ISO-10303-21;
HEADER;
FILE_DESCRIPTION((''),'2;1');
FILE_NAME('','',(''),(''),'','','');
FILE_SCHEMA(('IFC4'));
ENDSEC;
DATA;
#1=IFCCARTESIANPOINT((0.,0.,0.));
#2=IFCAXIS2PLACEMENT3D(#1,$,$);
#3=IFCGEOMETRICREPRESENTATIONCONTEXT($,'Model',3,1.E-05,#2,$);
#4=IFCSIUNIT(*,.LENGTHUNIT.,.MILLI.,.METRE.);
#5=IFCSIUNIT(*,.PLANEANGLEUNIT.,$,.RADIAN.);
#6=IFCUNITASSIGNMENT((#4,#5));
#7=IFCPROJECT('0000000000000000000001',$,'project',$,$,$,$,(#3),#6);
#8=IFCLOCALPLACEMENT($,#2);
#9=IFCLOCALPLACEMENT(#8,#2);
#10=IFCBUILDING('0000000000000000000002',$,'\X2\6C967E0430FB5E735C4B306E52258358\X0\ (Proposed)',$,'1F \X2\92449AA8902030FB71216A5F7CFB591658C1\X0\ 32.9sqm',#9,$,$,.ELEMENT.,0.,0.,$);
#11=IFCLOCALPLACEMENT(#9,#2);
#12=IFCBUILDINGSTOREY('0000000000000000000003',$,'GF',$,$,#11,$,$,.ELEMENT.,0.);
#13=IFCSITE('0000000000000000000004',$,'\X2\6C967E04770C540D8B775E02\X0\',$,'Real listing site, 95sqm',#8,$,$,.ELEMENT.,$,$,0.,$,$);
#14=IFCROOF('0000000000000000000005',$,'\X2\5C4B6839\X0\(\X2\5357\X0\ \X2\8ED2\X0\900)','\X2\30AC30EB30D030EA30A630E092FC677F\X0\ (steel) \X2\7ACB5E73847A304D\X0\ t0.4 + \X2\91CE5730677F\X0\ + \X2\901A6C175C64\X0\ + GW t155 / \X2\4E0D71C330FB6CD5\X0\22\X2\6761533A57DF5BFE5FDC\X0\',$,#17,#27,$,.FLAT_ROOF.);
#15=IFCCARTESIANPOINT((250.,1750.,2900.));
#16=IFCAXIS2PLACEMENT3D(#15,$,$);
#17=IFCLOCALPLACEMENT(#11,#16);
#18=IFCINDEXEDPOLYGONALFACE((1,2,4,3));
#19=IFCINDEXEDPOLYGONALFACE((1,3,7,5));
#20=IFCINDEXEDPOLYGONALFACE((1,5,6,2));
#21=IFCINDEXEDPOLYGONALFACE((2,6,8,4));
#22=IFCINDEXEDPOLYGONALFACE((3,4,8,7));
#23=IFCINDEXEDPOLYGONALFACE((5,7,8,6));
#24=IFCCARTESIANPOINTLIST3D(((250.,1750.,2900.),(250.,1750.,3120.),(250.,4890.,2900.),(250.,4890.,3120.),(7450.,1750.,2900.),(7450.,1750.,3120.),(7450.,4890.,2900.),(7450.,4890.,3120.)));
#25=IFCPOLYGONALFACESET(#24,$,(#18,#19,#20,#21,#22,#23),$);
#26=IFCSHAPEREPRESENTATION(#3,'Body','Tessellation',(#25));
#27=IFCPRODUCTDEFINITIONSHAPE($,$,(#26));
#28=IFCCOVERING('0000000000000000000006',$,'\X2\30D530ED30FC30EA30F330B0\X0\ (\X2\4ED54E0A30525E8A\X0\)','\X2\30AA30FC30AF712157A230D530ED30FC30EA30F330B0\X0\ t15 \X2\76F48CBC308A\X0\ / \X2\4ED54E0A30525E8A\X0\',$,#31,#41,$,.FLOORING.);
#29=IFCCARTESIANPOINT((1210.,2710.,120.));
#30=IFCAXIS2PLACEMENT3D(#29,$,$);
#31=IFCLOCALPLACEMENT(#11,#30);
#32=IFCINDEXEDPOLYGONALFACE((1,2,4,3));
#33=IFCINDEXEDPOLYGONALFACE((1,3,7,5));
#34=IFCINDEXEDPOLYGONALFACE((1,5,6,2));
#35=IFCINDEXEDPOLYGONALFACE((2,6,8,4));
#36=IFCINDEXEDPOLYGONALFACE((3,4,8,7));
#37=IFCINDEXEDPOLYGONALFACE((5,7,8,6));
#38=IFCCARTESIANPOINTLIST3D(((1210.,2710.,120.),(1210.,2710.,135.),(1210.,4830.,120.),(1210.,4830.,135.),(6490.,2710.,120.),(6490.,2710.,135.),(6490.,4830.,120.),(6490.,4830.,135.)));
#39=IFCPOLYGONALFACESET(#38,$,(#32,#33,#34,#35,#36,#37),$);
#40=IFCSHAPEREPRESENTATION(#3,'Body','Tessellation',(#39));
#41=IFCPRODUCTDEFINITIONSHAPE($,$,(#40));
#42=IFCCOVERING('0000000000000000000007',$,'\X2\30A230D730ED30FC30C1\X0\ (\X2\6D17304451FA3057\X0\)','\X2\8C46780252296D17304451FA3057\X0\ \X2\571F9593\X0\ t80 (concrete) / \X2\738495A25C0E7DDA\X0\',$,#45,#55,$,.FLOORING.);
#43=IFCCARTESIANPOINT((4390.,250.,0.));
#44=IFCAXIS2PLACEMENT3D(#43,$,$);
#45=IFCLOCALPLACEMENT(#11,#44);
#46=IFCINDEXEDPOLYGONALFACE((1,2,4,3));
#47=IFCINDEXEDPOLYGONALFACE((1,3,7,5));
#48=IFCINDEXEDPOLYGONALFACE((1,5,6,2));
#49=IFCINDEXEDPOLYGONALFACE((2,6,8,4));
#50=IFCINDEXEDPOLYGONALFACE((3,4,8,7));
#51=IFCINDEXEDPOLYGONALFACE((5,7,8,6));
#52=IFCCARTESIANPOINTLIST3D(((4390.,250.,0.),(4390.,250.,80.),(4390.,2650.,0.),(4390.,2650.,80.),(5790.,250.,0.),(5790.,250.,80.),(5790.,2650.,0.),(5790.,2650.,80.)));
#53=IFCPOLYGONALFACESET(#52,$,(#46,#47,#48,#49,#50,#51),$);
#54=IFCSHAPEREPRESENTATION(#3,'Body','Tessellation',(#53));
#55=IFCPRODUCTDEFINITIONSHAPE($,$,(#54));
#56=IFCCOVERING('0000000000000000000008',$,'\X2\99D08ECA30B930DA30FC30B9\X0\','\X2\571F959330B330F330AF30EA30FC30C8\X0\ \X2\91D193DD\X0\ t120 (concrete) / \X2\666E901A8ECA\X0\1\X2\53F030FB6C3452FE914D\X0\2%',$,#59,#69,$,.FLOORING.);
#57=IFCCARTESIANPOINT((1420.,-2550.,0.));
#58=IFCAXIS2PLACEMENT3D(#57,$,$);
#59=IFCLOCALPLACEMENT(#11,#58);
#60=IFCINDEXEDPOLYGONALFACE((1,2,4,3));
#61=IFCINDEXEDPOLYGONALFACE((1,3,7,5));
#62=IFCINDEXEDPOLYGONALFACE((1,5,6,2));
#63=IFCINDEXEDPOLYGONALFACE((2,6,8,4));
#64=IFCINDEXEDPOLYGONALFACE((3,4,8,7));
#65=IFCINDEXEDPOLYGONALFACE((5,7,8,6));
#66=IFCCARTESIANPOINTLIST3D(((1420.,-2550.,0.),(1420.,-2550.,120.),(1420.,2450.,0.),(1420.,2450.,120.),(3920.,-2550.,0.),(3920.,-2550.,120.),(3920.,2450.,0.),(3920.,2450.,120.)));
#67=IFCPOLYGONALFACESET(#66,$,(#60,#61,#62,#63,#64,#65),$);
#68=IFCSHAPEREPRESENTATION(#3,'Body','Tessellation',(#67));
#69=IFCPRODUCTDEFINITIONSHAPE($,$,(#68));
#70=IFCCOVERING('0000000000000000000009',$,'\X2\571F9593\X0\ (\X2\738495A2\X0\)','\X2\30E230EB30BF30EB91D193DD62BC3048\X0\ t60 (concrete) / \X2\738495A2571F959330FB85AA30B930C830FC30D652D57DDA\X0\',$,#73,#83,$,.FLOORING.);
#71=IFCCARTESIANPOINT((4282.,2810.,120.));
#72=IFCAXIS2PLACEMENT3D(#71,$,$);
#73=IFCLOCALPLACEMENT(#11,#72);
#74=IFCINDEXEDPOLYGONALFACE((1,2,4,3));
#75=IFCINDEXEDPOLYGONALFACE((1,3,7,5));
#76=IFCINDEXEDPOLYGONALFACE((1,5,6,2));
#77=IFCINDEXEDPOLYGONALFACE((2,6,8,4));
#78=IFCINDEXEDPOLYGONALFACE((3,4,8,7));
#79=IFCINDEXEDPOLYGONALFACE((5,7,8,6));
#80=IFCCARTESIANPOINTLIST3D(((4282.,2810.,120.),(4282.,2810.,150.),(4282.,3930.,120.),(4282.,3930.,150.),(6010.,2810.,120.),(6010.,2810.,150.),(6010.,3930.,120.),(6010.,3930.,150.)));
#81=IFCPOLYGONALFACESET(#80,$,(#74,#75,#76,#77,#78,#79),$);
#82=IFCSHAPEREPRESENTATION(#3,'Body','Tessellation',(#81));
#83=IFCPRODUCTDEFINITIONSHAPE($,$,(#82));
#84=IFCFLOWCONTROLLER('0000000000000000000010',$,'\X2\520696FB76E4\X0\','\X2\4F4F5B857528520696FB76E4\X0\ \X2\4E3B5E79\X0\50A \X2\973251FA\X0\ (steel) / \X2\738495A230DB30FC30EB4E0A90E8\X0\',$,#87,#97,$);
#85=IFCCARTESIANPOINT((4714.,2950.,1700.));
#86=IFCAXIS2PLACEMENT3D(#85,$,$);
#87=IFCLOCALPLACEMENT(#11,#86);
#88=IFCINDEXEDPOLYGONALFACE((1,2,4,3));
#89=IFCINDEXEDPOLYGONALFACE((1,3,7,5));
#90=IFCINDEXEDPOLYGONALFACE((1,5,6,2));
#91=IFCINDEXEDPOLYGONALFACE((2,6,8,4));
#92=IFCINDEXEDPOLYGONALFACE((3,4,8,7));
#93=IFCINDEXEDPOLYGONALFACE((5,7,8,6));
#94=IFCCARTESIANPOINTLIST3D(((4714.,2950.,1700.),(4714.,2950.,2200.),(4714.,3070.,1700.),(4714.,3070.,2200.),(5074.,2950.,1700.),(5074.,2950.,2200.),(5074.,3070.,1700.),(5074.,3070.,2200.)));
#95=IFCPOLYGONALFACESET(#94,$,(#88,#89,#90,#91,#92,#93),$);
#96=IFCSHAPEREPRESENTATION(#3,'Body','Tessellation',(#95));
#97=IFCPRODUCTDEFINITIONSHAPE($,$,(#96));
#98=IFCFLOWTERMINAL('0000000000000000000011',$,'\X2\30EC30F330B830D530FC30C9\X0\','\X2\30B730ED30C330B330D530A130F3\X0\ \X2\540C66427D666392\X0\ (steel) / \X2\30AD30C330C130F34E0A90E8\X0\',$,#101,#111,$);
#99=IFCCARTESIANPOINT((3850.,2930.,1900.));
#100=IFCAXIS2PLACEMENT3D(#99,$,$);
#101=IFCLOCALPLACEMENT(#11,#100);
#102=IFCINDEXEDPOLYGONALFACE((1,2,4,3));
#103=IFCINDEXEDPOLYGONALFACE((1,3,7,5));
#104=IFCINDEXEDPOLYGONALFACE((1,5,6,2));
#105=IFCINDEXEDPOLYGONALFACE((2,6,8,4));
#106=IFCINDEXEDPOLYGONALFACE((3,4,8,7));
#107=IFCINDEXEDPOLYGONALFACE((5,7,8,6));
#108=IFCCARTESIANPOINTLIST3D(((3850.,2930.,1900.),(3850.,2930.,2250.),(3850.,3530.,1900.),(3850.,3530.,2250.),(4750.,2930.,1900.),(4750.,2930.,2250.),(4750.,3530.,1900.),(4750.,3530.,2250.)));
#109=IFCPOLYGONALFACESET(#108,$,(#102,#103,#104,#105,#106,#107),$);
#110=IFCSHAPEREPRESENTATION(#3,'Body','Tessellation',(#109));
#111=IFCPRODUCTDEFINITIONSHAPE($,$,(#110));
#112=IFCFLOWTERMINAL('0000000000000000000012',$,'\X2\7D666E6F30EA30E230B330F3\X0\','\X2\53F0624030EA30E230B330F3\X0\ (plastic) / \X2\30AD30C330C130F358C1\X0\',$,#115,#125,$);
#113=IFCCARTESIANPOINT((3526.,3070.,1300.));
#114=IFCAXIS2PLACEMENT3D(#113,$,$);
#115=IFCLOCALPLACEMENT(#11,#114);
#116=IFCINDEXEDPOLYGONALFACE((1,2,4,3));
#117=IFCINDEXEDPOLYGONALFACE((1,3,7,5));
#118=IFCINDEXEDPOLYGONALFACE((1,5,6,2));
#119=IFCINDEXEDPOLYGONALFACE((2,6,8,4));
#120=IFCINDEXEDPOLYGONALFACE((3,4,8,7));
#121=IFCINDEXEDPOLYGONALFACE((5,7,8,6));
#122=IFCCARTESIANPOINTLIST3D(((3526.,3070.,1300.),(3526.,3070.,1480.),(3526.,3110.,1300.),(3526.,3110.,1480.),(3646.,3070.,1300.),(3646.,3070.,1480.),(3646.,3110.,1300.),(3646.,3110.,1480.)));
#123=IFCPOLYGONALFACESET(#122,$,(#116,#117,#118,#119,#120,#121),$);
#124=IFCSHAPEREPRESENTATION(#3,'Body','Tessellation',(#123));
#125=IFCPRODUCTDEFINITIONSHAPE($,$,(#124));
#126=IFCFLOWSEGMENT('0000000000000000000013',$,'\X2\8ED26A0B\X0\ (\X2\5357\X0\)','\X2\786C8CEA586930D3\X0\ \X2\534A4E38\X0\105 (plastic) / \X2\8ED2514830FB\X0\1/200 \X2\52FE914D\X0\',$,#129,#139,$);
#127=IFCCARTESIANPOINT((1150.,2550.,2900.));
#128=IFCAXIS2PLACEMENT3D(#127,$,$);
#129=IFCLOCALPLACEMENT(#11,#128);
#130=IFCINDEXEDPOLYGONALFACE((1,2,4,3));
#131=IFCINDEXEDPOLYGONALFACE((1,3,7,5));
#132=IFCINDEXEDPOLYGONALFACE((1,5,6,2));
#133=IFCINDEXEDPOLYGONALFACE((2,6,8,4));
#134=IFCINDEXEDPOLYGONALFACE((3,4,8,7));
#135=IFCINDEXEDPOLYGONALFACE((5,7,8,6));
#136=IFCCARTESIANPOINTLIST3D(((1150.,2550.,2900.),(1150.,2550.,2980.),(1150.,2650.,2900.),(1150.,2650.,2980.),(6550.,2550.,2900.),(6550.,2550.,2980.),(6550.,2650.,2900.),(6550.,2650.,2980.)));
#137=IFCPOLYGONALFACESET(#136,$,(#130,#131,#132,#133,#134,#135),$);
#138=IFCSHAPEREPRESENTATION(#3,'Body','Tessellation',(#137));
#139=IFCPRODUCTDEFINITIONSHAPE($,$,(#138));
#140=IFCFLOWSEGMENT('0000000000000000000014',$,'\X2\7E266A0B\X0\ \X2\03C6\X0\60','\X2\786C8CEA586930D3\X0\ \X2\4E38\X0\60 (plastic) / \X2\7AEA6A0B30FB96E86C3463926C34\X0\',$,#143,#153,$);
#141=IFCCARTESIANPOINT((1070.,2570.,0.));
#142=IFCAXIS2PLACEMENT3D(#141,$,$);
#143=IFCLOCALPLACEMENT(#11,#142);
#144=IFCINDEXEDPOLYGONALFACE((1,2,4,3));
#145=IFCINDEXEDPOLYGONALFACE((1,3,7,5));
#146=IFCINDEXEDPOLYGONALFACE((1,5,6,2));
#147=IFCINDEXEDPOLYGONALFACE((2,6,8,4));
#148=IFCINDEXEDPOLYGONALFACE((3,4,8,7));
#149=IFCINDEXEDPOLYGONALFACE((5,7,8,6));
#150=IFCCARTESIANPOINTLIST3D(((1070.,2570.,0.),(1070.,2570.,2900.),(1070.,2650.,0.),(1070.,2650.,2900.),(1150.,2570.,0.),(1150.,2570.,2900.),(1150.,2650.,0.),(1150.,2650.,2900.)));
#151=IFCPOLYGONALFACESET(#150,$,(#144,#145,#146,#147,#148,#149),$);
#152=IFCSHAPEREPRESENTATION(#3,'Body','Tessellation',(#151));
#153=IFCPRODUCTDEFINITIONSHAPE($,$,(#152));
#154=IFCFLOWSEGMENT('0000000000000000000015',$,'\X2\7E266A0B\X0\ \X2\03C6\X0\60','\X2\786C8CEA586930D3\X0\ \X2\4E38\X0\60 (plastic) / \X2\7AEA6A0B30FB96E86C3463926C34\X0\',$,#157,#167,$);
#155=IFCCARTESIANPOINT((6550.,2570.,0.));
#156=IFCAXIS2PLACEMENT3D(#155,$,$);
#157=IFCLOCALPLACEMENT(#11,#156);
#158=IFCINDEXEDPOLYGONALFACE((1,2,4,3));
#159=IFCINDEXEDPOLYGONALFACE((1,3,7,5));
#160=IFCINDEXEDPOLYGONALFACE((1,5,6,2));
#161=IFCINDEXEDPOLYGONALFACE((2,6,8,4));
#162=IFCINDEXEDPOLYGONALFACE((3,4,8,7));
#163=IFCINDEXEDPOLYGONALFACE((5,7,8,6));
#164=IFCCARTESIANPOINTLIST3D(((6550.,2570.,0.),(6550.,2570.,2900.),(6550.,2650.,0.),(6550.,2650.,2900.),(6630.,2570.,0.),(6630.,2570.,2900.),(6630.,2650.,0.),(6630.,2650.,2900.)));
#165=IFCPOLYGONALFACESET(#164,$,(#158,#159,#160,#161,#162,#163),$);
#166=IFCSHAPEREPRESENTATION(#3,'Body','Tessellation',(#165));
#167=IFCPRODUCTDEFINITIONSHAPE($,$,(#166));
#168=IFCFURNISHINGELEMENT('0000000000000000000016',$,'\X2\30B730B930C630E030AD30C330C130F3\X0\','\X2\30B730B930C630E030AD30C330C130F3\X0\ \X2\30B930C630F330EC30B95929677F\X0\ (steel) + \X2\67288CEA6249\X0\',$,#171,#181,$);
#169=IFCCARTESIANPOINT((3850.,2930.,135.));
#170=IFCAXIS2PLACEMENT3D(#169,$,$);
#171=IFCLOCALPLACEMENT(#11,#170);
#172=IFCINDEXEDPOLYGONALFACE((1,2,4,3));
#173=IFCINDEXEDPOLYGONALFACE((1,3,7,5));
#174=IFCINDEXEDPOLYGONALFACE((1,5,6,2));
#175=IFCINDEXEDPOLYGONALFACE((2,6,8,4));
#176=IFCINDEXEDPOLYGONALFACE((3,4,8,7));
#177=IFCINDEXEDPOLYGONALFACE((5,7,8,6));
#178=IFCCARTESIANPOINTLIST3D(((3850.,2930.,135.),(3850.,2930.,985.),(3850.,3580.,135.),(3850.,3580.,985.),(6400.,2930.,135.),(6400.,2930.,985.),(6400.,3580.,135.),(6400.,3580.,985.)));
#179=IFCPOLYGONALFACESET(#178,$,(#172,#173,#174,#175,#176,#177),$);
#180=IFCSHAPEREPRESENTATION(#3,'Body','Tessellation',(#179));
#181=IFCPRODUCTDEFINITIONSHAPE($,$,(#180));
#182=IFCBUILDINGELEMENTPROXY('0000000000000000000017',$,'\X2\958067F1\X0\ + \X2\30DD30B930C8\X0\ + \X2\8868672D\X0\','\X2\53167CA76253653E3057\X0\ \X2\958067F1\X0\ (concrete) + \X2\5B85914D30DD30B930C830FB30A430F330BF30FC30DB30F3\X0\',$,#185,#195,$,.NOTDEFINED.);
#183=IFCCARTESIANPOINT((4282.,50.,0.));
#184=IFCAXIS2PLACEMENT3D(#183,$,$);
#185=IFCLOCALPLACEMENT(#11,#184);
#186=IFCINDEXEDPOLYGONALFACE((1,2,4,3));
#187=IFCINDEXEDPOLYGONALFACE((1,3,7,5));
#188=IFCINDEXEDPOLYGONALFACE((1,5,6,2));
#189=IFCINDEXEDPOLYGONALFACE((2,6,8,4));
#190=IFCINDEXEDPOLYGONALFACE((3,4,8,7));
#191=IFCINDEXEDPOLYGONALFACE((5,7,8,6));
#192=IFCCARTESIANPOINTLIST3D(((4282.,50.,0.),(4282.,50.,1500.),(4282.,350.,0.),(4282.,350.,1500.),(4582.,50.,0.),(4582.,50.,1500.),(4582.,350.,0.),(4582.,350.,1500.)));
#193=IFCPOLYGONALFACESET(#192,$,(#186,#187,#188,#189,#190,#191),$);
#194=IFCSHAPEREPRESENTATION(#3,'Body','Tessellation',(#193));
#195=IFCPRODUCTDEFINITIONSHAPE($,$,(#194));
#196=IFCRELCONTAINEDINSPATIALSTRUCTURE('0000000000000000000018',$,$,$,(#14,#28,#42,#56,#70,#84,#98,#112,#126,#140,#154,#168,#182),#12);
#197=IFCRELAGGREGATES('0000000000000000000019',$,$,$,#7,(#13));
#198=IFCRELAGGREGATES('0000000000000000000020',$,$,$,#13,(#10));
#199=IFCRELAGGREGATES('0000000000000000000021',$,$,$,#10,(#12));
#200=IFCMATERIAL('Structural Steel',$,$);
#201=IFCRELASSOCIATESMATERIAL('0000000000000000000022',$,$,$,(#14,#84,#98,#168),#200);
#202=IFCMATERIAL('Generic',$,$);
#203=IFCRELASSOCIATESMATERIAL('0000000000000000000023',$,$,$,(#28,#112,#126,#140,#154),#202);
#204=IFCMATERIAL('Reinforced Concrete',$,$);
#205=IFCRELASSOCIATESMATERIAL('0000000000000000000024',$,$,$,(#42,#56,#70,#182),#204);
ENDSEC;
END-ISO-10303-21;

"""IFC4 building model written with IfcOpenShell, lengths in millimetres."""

from ifc_helpers import new_model, si_unit, frame, frame_2d, origin, place, context, project, spatial, rectangle, extrude, material, element, save


model = new_model("IFC4")

# Units and contexts
model_context = context("Model", 3, precision=1e-05, world=origin())
ifc_project = project(units=[si_unit("LENGTHUNIT", "METRE", prefix="MILLI"), si_unit("PLANEANGLEUNIT", "RADIAN")], contexts=[model_context])

# Site, building, storey
site_placement = place(None, origin())
site = spatial("IfcSite", under=ifc_project, at=site_placement, Name="沖縄県名護市", ObjectType="Real listing site, 95sqm", CompositionType="ELEMENT", RefElevation=0.0)
building_placement = place(site_placement, origin())
building = spatial("IfcBuilding", under=site, at=building_placement, Name="沖縄・平屋の別荘 (Proposed)", ObjectType="1F 鉄骨造・無機系外壁 32.9sqm", CompositionType="ELEMENT", ElevationOfRefHeight=0.0, ElevationOfTerrain=0.0)
storey_placement = place(building_placement, origin())
storey = spatial("IfcBuildingStorey", under=building, at=storey_placement, Name="GF", CompositionType="ELEMENT", Elevation=0.0)

# Shared definitions
ifc_material_1 = material(Name="Reinforced Concrete")

# Roof
ifc_material_2 = material(Name="Structural Steel")
roof_placement = place(storey_placement, frame((250.0, 1750.0, 2900.0)))
element("IfcRoof", 1, at=roof_placement, inside=storey, material=ifc_material_2, Name="屋根(南 軒900)", Description="ガルバリウム鋼板 (steel) 立平葺き t0.4 + 野地板 + 通気層 + GW t155 / 不燃・法22条区域対応", PredefinedType="FLAT_ROOF", context=model_context, shape_type="SweptSolid", body=[
    extrude(rectangle(XDim=7200.0, YDim=3140.0, at=frame_2d((3600.0, 1570.0))), frame((250.0, 1750.0, 2900.0)), (0.0, 0.0, 1.0), 220.0),
])

# Coverings
ifc_material_3 = material(Name="Generic")
covering_1_placement = place(storey_placement, frame((1210.0, 2710.0, 120.0)))
element("IfcCovering", 2, at=covering_1_placement, inside=storey, material=ifc_material_3, Name="フローリング (仕上げ床)", Description="オーク無垢フローリング t15 直貼り / 仕上げ床", PredefinedType="FLOORING", context=model_context, shape_type="SweptSolid", body=[
    extrude(rectangle(XDim=5280.0, YDim=2120.0, at=frame_2d((2640.0, 1060.0))), frame((1210.0, 2710.0, 120.0)), (0.0, 0.0, 1.0), 15.0),
])
covering_2_placement = place(storey_placement, frame((4390.0, 250.0, 0.0)))
element("IfcCovering", 3, at=covering_2_placement, inside=storey, material=ifc_material_1, Name="アプローチ (洗い出し)", Description="豆砂利洗い出し 土間 t80 (concrete) / 玄関導線", PredefinedType="FLOORING", context=model_context, shape_type="SweptSolid", body=[
    extrude(rectangle(XDim=1400.0, YDim=2400.0, at=frame_2d((700.0, 1200.0))), frame((4390.0, 250.0, 0.0)), (0.0, 0.0, 1.0), 80.0),
])
covering_3_placement = place(storey_placement, frame((1420.0, -2550.0, 0.0)))
element("IfcCovering", 4, at=covering_3_placement, inside=storey, material=ifc_material_1, Name="駐車スペース", Description="土間コンクリート 金鏝 t120 (concrete) / 普通車1台・水勾配2%", PredefinedType="FLOORING", context=model_context, shape_type="SweptSolid", body=[
    extrude(rectangle(XDim=2500.0, YDim=5000.0, at=frame_2d((1250.0, 2500.0))), frame((1420.0, -2550.0, 0.0)), (0.0, 0.0, 1.0), 120.0),
])
covering_4_placement = place(storey_placement, frame((4282.0, 2810.0, 120.0)))
element("IfcCovering", 5, at=covering_4_placement, inside=storey, material=ifc_material_1, Name="土間 (玄関)", Description="モルタル金鏝押え t60 (concrete) / 玄関土間・薪ストーブ動線", PredefinedType="FLOORING", context=model_context, shape_type="SweptSolid", body=[
    extrude(rectangle(XDim=1728.0, YDim=1120.0, at=frame_2d((864.0, 560.0))), frame((4282.0, 2810.0, 120.0)), (0.0, 0.0, 1.0), 30.0),
])

# Flow controller
flow_controller_placement = place(storey_placement, frame((4714.0, 2950.0, 1700.0)))
element("IfcFlowController", 6, at=flow_controller_placement, inside=storey, material=ifc_material_2, Name="分電盤", Description="住宅用分電盤 主幹50A 露出 (steel) / 玄関ホール上部", context=model_context, shape_type="SweptSolid", body=[
    extrude(rectangle(XDim=360.0, YDim=120.0, at=frame_2d((180.0, 60.0))), frame((4714.0, 2950.0, 1700.0)), (0.0, 0.0, 1.0), 500.0),
])

# Flow terminals
flow_terminal_1_placement = place(storey_placement, frame((3850.0, 2930.0, 1900.0)))
element("IfcFlowTerminal", 7, at=flow_terminal_1_placement, inside=storey, material=ifc_material_2, Name="レンジフード", Description="シロッコファン 同時給排 (steel) / キッチン上部", context=model_context, shape_type="SweptSolid", body=[
    extrude(rectangle(XDim=900.0, YDim=600.0, at=frame_2d((450.0, 300.0))), frame((3850.0, 2930.0, 1900.0)), (0.0, 0.0, 1.0), 350.0),
])
flow_terminal_2_placement = place(storey_placement, frame((3526.0, 3070.0, 1300.0)))
element("IfcFlowTerminal", 8, at=flow_terminal_2_placement, inside=storey, material=ifc_material_3, Name="給湯リモコン", Description="台所リモコン (plastic) / キッチン壁", context=model_context, shape_type="SweptSolid", body=[
    extrude(rectangle(XDim=120.0, YDim=40.0, at=frame_2d((60.0, 20.0))), frame((3526.0, 3070.0, 1300.0)), (0.0, 0.0, 1.0), 180.0),
])

# Flow segments
flow_segment_1_placement = place(storey_placement, frame((1150.0, 2550.0, 2900.0)))
element("IfcFlowSegment", 9, at=flow_segment_1_placement, inside=storey, material=ifc_material_3, Name="軒樋 (南)", Description="硬質塩ビ 半丸105 (plastic) / 軒先・1/200 勾配", context=model_context, shape_type="SweptSolid", body=[
    extrude(rectangle(XDim=5400.0, YDim=100.0, at=frame_2d((2700.0, 50.0))), frame((1150.0, 2550.0, 2900.0)), (0.0, 0.0, 1.0), 80.0),
])
flow_segment_2_placement = place(storey_placement, frame((1070.0, 2570.0, 0.0)))
element("IfcFlowSegment", 10, at=flow_segment_2_placement, inside=storey, material=ifc_material_3, Name="縦樋 φ60", Description="硬質塩ビ 丸60 (plastic) / 竪樋・雨水排水", context=model_context, shape_type="SweptSolid", body=[
    extrude(rectangle(XDim=80.0, YDim=80.0, at=frame_2d((40.0, 40.0))), frame((1070.0, 2570.0, 0.0)), (0.0, 0.0, 1.0), 2900.0),
])
flow_segment_3_placement = place(storey_placement, frame((6550.0, 2570.0, 0.0)))
element("IfcFlowSegment", 11, at=flow_segment_3_placement, inside=storey, material=ifc_material_3, Name="縦樋 φ60", Description="硬質塩ビ 丸60 (plastic) / 竪樋・雨水排水", context=model_context, shape_type="SweptSolid", body=[
    extrude(rectangle(XDim=80.0, YDim=80.0, at=frame_2d((40.0, 40.0))), frame((6550.0, 2570.0, 0.0)), (0.0, 0.0, 1.0), 2900.0),
])

# Furnishing element
furnishing_placement = place(storey_placement, frame((3850.0, 2930.0, 135.0)))
element("IfcFurnishingElement", 12, at=furnishing_placement, inside=storey, material=ifc_material_2, Name="システムキッチン", Description="システムキッチン ステンレス天板 (steel) + 木質扉", context=model_context, shape_type="SweptSolid", body=[
    extrude(rectangle(XDim=2550.0, YDim=650.0, at=frame_2d((1275.0, 325.0))), frame((3850.0, 2930.0, 135.0)), (0.0, 0.0, 1.0), 850.0),
])

# Building element proxy
proxy_placement = place(storey_placement, frame((4282.0, 50.0, 0.0)))
element("IfcBuildingElementProxy", 13, at=proxy_placement, inside=storey, material=ifc_material_1, Name="門柱 + ポスト + 表札", Description="化粧打放し 門柱 (concrete) + 宅配ポスト・インターホン", PredefinedType="NOTDEFINED", context=model_context, shape_type="SweptSolid", body=[
    extrude(rectangle(XDim=300.0, YDim=300.0, at=frame_2d((150.0, 150.0))), frame((4282.0, 50.0, 0.0)), (0.0, 0.0, 1.0), 1500.0),
])

save(model, "model.ifc")
